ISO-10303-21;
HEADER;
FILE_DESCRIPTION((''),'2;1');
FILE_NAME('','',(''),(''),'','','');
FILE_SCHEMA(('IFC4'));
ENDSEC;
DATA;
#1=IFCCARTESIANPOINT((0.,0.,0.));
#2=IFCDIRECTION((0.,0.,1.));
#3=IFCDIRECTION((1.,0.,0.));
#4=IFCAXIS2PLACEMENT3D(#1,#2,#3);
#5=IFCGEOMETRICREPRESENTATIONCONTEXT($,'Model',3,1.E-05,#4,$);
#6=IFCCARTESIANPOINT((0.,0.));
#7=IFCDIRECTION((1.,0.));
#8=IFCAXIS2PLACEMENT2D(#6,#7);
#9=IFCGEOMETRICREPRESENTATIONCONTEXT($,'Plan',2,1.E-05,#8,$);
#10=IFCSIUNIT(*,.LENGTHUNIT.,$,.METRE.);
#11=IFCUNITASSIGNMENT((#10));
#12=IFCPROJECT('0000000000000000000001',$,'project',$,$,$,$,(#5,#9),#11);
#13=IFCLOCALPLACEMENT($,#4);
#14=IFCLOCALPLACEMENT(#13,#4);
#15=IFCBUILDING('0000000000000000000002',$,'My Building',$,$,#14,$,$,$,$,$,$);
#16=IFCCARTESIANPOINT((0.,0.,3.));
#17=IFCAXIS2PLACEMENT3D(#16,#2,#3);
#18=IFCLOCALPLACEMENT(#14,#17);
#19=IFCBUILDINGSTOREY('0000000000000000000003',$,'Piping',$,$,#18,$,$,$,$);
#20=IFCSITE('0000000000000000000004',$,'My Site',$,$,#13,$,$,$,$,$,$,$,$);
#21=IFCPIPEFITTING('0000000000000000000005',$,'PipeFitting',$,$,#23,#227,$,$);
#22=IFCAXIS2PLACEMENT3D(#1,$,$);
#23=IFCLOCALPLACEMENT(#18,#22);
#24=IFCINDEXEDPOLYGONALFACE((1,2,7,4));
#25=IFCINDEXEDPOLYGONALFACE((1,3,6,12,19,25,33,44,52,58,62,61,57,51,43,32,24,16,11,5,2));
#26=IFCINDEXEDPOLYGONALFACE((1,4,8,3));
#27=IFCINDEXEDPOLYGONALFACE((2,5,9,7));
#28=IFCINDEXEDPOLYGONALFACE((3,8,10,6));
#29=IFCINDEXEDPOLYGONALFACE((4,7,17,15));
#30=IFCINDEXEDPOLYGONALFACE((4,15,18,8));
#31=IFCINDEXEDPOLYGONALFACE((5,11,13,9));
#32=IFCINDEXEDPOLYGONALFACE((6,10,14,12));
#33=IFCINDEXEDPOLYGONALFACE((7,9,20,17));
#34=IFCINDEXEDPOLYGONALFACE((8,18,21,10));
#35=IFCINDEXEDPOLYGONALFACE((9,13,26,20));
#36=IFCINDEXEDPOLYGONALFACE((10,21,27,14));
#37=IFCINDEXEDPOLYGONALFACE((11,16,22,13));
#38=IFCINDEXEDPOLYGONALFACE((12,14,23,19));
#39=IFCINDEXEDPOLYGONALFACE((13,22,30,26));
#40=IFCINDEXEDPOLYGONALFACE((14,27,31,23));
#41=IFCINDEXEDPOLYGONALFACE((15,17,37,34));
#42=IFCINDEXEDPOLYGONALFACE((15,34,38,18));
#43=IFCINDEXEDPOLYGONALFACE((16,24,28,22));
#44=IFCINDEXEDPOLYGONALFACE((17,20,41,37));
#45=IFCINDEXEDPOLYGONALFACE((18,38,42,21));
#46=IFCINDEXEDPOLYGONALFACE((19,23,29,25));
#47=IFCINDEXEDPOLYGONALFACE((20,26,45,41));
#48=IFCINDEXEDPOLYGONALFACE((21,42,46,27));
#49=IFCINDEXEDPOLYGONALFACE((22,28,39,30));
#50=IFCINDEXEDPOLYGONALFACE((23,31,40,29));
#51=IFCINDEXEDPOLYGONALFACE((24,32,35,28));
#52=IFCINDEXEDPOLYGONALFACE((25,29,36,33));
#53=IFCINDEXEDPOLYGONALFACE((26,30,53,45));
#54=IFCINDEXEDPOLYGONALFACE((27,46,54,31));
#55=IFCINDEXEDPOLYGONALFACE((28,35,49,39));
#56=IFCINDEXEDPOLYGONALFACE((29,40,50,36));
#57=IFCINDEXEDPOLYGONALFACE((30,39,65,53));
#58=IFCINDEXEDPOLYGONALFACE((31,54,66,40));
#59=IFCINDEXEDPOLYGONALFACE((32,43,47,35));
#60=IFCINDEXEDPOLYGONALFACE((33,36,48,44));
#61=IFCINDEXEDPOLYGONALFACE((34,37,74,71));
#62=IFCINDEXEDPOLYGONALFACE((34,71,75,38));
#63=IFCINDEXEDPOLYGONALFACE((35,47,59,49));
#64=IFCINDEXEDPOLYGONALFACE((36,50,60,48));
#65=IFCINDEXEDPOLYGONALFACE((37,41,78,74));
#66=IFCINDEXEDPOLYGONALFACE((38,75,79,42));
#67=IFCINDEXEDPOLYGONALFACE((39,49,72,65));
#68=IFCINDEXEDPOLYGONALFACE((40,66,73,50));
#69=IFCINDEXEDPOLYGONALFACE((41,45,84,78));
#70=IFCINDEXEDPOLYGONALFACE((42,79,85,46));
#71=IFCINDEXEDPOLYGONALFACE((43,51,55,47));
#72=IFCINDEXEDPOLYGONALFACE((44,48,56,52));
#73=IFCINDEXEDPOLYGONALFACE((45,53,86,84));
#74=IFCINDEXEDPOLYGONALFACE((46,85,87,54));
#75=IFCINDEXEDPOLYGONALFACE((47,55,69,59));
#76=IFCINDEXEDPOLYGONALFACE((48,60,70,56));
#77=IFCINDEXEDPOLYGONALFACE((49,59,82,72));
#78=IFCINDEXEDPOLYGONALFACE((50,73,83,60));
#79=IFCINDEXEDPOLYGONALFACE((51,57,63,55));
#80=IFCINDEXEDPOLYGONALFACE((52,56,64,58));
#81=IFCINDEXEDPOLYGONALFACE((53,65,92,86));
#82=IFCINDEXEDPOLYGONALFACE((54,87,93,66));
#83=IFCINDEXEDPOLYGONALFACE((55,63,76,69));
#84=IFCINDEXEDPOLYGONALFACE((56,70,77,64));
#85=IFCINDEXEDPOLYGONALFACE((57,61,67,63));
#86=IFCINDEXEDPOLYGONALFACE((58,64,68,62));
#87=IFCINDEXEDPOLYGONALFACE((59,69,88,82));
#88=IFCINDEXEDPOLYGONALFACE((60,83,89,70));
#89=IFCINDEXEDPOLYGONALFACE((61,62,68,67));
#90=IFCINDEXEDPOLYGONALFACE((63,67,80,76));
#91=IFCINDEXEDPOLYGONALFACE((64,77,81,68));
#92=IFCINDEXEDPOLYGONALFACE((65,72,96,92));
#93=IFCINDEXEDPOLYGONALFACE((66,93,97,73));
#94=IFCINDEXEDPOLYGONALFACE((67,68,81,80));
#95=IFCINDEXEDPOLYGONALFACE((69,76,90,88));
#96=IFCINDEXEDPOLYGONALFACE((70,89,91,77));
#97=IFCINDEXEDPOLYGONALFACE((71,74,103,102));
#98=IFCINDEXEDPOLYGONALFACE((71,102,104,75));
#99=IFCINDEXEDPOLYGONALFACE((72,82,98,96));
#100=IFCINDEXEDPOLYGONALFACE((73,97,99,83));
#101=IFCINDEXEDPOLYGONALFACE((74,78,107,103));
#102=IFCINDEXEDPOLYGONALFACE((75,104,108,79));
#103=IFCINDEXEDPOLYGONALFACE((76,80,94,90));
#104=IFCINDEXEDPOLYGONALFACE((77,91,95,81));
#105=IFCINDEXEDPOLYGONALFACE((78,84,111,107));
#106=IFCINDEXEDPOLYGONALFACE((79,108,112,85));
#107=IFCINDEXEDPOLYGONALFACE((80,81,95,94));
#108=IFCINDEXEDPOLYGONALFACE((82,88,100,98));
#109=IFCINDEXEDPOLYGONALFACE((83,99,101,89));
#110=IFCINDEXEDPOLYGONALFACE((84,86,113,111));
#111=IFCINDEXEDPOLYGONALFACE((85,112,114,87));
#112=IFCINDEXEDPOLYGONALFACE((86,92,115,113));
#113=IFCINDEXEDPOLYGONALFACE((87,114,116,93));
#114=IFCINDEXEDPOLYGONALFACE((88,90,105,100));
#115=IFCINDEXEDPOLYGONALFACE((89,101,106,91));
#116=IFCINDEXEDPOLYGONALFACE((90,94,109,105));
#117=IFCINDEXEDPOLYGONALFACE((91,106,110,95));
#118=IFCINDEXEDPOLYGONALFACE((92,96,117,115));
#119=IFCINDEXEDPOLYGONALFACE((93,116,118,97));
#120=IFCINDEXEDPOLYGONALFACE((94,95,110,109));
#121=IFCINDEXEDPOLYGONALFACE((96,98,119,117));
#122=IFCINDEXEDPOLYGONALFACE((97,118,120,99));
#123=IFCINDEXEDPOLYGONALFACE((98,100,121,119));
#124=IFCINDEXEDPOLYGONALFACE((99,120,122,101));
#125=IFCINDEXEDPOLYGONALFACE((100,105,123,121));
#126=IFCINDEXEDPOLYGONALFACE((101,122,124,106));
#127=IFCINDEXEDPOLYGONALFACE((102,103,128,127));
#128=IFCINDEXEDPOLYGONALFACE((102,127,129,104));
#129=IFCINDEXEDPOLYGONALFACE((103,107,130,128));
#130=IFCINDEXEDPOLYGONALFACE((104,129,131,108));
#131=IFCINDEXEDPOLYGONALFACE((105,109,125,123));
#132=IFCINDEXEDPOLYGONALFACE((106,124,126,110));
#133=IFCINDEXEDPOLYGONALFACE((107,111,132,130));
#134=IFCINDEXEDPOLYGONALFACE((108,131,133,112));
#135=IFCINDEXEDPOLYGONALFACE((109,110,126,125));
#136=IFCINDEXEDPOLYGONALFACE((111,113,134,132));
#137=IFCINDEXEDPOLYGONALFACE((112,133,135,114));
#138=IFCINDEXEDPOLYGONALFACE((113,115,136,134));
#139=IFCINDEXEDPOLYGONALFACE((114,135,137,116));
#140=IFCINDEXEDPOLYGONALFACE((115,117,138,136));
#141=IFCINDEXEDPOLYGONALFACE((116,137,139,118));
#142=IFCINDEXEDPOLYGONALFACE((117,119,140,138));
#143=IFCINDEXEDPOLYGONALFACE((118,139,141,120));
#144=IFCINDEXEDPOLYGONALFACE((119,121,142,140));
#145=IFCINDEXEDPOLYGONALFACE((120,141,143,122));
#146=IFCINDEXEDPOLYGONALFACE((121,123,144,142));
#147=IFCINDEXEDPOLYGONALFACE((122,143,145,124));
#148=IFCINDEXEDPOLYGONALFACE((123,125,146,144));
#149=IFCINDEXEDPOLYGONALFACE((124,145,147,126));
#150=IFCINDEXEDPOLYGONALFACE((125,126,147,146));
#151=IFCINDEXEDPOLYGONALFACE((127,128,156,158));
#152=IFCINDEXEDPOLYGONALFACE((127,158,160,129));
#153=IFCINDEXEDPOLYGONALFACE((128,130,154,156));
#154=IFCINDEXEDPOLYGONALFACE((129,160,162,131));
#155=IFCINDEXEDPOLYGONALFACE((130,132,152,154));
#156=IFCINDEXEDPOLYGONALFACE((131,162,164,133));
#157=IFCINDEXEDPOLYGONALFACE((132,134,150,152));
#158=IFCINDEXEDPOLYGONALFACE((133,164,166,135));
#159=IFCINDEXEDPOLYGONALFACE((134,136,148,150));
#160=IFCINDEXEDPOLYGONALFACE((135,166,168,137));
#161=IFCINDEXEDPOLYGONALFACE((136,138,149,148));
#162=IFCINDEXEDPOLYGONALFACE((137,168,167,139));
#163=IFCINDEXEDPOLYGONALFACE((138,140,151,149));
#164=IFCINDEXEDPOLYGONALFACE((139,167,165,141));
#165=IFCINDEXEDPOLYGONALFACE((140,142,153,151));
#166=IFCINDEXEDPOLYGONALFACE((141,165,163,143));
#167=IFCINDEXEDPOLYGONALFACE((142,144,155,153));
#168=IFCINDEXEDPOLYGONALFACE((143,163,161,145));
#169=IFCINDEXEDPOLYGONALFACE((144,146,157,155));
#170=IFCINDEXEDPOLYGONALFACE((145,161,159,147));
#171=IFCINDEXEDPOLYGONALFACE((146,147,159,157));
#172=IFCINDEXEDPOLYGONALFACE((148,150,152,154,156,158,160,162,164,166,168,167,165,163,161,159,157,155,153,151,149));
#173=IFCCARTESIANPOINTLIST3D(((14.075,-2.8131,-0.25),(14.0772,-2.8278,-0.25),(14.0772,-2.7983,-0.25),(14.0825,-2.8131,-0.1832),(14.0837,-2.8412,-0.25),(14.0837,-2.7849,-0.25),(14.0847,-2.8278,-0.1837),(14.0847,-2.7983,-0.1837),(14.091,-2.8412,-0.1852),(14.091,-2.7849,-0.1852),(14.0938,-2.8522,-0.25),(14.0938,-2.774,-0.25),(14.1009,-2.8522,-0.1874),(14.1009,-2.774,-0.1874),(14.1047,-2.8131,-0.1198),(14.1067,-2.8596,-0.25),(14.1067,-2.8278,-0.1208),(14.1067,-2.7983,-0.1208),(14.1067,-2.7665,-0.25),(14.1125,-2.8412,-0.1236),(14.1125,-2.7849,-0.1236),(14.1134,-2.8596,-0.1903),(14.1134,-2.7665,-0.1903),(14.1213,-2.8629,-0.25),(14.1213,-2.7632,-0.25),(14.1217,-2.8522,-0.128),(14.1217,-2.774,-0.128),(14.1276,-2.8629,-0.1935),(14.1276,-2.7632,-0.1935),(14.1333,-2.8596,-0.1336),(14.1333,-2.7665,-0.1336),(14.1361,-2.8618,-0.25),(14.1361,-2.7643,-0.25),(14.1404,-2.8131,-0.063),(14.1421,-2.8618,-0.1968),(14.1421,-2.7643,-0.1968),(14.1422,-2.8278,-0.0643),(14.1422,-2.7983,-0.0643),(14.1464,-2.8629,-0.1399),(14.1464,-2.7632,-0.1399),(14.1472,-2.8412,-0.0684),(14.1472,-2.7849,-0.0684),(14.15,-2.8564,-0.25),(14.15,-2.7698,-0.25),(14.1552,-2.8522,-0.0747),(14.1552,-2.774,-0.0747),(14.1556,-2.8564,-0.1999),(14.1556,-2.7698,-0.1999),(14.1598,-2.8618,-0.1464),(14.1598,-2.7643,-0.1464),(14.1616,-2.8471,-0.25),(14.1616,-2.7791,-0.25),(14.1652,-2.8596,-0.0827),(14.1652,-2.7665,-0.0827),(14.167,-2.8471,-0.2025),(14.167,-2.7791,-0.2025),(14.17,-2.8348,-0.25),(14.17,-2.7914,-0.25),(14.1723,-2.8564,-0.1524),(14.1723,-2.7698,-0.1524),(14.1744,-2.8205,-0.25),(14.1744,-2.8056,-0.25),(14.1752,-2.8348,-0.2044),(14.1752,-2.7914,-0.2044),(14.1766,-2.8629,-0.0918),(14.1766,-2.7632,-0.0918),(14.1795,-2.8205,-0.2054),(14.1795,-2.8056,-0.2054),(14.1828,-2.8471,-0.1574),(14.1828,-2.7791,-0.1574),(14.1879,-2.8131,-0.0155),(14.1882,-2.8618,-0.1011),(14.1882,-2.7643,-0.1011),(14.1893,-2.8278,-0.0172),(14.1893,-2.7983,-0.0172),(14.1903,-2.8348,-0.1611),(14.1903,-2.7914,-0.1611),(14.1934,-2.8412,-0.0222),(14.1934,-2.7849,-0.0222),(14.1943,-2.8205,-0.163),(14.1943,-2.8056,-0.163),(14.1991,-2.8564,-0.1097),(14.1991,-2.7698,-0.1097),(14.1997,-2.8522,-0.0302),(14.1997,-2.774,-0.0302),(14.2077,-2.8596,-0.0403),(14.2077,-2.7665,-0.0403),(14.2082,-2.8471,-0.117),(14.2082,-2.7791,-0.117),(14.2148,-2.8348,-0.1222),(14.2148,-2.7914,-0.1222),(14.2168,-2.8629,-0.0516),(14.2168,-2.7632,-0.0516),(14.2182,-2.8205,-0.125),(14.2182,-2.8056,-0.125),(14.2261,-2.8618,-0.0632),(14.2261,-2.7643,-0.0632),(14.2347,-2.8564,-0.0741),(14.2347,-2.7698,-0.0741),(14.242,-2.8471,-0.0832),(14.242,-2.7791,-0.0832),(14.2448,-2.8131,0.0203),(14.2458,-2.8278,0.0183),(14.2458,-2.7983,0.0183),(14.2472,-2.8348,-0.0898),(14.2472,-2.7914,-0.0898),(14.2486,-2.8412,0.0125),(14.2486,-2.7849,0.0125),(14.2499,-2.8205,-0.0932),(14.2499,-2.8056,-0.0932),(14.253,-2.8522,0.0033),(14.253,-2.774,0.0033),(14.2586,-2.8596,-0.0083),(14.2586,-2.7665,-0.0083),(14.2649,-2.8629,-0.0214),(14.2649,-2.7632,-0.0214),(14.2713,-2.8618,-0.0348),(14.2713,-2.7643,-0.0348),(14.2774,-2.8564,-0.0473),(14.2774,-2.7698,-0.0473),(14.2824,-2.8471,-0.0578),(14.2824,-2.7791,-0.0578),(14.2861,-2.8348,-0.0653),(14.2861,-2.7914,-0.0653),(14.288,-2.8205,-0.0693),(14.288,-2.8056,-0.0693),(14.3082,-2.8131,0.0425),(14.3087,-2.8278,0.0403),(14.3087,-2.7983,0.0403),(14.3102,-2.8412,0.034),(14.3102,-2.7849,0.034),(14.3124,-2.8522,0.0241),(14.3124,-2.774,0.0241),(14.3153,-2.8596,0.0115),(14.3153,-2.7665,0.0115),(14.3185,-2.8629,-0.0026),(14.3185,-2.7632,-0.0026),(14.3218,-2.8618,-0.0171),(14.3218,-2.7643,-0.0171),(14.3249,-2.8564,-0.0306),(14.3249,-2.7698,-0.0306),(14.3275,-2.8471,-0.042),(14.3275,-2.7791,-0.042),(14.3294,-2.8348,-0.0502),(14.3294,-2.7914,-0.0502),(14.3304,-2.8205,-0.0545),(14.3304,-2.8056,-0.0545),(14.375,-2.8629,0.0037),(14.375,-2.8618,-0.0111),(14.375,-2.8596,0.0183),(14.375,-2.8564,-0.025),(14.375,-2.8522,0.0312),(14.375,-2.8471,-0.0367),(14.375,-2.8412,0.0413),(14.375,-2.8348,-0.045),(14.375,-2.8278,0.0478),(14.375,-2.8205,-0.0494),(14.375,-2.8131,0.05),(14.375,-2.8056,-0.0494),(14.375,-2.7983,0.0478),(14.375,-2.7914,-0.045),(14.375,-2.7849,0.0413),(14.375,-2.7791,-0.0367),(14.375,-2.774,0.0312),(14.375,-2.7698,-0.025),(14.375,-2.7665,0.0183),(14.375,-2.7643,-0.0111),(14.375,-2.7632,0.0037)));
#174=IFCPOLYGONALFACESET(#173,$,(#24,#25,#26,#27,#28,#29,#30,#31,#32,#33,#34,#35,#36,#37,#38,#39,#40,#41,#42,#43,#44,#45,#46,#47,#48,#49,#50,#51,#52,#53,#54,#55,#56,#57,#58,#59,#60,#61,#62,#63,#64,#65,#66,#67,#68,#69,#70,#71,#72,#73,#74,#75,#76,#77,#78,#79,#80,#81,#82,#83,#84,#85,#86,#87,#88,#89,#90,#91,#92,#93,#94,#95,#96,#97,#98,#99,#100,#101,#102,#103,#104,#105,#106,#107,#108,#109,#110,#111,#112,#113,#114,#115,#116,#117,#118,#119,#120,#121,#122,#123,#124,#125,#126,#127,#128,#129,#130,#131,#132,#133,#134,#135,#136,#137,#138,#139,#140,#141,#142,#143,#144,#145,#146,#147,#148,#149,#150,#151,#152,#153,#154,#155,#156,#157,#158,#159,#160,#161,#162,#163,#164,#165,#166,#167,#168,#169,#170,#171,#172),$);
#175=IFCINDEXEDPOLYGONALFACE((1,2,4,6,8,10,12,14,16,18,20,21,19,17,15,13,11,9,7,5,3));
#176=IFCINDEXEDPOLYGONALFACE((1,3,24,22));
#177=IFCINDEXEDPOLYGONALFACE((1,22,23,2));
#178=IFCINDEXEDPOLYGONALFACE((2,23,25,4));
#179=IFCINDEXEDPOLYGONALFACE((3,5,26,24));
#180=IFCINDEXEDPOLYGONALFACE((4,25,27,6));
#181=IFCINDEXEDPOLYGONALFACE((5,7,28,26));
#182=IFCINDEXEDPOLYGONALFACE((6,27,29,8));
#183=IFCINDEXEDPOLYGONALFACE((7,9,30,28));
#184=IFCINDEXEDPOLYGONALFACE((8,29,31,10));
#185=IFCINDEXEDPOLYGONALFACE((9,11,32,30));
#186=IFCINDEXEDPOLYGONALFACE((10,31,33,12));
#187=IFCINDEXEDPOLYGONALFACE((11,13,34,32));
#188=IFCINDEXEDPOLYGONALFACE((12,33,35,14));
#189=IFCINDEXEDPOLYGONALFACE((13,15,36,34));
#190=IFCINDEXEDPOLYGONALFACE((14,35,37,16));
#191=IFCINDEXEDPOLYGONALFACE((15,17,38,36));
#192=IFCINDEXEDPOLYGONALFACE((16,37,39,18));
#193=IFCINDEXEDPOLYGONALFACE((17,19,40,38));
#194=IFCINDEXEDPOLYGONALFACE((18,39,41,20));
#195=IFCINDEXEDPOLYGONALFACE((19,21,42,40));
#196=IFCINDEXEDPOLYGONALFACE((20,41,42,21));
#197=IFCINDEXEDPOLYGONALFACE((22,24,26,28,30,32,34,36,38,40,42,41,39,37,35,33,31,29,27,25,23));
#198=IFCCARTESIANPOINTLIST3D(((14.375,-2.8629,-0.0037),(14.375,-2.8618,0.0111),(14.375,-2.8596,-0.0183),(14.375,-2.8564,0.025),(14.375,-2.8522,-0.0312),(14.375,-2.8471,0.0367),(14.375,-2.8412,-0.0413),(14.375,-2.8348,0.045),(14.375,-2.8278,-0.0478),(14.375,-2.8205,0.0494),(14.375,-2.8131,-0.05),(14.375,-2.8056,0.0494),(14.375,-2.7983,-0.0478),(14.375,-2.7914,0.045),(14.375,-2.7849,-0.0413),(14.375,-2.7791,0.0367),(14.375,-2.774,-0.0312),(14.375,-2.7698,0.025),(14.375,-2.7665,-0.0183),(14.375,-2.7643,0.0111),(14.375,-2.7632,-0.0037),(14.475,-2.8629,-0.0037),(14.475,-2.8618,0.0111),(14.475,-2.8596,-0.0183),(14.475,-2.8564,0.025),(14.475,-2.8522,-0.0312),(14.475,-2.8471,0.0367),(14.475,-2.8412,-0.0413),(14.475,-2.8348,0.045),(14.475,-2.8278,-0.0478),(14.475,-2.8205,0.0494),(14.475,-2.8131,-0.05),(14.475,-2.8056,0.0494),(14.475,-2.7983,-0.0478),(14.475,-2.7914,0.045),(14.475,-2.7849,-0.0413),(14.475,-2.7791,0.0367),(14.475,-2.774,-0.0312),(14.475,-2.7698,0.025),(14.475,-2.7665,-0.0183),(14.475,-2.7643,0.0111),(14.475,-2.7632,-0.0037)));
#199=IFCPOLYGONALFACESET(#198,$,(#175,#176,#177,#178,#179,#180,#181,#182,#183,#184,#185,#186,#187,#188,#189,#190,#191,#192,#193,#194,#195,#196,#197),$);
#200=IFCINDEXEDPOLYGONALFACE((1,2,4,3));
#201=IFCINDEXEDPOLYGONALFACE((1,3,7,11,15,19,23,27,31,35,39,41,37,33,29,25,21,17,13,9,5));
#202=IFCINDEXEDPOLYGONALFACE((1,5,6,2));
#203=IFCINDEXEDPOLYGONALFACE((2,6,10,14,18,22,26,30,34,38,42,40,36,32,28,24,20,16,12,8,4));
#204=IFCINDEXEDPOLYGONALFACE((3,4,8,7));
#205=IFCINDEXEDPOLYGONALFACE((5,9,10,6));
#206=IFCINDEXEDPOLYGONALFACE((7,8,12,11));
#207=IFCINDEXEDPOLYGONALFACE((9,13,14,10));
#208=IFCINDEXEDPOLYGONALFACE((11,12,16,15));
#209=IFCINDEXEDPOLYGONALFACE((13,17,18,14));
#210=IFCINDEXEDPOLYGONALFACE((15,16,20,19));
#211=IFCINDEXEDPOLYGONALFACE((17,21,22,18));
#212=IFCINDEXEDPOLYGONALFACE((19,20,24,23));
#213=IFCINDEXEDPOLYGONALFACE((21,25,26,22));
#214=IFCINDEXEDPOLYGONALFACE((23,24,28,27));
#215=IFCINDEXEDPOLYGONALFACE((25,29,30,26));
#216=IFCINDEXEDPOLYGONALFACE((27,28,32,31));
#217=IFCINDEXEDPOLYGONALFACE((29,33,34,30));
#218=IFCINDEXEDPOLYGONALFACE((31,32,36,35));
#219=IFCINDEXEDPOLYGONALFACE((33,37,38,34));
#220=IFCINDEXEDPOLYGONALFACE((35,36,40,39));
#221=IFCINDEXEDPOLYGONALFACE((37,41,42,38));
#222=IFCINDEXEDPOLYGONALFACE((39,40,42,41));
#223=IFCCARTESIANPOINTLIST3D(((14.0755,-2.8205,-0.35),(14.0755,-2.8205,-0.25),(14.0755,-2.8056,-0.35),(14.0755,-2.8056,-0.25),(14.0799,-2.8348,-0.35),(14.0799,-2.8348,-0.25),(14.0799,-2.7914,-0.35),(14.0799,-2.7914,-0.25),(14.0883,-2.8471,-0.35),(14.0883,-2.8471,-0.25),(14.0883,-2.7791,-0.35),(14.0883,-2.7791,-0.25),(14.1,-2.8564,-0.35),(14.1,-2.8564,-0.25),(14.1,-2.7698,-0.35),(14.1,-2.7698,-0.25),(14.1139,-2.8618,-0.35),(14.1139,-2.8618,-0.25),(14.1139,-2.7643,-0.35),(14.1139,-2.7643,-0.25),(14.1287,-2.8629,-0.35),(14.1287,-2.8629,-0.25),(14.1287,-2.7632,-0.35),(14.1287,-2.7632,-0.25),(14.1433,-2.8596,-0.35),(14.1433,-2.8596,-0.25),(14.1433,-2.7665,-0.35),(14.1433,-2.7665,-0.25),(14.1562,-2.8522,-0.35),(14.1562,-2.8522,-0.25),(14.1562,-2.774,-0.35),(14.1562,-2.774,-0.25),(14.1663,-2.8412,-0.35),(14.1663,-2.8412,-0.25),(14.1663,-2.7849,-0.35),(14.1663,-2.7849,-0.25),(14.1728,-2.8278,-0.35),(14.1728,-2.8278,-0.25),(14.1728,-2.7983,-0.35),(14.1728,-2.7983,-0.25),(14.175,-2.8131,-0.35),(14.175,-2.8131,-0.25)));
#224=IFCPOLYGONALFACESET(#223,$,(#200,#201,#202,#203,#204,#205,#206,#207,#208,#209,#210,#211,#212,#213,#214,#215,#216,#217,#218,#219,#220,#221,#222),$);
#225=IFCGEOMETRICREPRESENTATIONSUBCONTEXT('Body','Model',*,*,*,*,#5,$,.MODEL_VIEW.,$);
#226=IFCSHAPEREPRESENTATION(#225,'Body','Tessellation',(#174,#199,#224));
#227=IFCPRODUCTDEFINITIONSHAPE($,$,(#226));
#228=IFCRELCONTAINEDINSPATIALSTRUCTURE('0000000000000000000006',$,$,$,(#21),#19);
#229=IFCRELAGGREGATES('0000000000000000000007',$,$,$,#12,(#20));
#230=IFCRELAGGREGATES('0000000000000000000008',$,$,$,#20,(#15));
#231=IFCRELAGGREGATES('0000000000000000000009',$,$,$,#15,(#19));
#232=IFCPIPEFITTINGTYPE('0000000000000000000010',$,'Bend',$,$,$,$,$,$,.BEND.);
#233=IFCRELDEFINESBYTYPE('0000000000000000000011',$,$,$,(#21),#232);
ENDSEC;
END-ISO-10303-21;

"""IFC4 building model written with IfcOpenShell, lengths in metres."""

from ifc_helpers import new_model, entity, si_unit, frame, origin_with_axes, origin_2d_with_axis, place, context, subcontext, project, spatial, circle, extrude, source, transform, mapped, type_object, type_shapes, element, save


model = new_model("IFC4")

# Units and contexts
model_context = context("Model", 3, precision=1e-05, world=origin_with_axes())
plan_context = context("Plan", 2, precision=1e-05, world=origin_2d_with_axis())
body_context = subcontext(model_context, "Body", "Model", "MODEL_VIEW")
ifc_project = project(units=[si_unit("LENGTHUNIT", "METRE")], contexts=[model_context, plan_context])

# Site, building, storey
site_placement = place(None, origin_with_axes())
site = spatial("IfcSite", under=ifc_project, at=site_placement, Name="My Site")
building_placement = place(site_placement, origin_with_axes())
building = spatial("IfcBuilding", under=site, at=building_placement, Name="My Building")
storey_placement = place(building_placement, frame((0.0, 0.0, 3.0), z_axis=(0.0, 0.0, 1.0), x_axis=(1.0, 0.0, 0.0)))
storey = spatial("IfcBuildingStorey", under=building, at=storey_placement, Name="Piping")

# Pipe fitting
pipe_fitting_type_1 = type_object("IfcPipeFittingType", Name="Bend", PredefinedType="BEND")
shared_shape_1 = source(origin_with_axes(), body_context, "Body", "SolidModel", [
    entity("IfcSweptDiskSolid", entity("IfcIndexedPolyCurve", entity("IfcCartesianPointList3D", [[0.0, 0.0, -0.1], [0.0732, 0.0, -0.2768], [0.25, 0.0, -0.35]]), [entity("IfcArcIndex", [1, 2, 3])]), 0.05),
    extrude(circle(Radius=0.05), origin_with_axes(), (0.0, 0.0, -1.0), 0.1),
    extrude(circle(Radius=0.05), frame((0.25, 0.0, -0.35), z_axis=(1.0, 0.0, 0.0), x_axis=(0.0, 0.0, 1.0)), (0.0, 0.0, 1.0), 0.1),
])
type_shapes(pipe_fitting_type_1, [shared_shape_1])
for number, where, z_axis, x_axis, name in (
    (1, (14.475, -2.8131, 0.0), (1.0, 0.0, 0.0), (0.0, 0.0, -1.0), "PipeFitting"),
):
    element("IfcPipeFitting", number, at=place(storey_placement, frame(where, z_axis=z_axis, x_axis=x_axis)), inside=storey, type_object=pipe_fitting_type_1, Name=name, context=body_context, shape_type="MappedRepresentation", body=[
        mapped(shared_shape_1, transform((0.0, 0.0, 0.0), x_axis=(1.0, 0.0, 0.0), y_axis=(0.0, 1.0, 0.0), z_axis=(0.0, 0.0, 1.0), scale=1.0)),
    ])

save(model, "model.ifc")
